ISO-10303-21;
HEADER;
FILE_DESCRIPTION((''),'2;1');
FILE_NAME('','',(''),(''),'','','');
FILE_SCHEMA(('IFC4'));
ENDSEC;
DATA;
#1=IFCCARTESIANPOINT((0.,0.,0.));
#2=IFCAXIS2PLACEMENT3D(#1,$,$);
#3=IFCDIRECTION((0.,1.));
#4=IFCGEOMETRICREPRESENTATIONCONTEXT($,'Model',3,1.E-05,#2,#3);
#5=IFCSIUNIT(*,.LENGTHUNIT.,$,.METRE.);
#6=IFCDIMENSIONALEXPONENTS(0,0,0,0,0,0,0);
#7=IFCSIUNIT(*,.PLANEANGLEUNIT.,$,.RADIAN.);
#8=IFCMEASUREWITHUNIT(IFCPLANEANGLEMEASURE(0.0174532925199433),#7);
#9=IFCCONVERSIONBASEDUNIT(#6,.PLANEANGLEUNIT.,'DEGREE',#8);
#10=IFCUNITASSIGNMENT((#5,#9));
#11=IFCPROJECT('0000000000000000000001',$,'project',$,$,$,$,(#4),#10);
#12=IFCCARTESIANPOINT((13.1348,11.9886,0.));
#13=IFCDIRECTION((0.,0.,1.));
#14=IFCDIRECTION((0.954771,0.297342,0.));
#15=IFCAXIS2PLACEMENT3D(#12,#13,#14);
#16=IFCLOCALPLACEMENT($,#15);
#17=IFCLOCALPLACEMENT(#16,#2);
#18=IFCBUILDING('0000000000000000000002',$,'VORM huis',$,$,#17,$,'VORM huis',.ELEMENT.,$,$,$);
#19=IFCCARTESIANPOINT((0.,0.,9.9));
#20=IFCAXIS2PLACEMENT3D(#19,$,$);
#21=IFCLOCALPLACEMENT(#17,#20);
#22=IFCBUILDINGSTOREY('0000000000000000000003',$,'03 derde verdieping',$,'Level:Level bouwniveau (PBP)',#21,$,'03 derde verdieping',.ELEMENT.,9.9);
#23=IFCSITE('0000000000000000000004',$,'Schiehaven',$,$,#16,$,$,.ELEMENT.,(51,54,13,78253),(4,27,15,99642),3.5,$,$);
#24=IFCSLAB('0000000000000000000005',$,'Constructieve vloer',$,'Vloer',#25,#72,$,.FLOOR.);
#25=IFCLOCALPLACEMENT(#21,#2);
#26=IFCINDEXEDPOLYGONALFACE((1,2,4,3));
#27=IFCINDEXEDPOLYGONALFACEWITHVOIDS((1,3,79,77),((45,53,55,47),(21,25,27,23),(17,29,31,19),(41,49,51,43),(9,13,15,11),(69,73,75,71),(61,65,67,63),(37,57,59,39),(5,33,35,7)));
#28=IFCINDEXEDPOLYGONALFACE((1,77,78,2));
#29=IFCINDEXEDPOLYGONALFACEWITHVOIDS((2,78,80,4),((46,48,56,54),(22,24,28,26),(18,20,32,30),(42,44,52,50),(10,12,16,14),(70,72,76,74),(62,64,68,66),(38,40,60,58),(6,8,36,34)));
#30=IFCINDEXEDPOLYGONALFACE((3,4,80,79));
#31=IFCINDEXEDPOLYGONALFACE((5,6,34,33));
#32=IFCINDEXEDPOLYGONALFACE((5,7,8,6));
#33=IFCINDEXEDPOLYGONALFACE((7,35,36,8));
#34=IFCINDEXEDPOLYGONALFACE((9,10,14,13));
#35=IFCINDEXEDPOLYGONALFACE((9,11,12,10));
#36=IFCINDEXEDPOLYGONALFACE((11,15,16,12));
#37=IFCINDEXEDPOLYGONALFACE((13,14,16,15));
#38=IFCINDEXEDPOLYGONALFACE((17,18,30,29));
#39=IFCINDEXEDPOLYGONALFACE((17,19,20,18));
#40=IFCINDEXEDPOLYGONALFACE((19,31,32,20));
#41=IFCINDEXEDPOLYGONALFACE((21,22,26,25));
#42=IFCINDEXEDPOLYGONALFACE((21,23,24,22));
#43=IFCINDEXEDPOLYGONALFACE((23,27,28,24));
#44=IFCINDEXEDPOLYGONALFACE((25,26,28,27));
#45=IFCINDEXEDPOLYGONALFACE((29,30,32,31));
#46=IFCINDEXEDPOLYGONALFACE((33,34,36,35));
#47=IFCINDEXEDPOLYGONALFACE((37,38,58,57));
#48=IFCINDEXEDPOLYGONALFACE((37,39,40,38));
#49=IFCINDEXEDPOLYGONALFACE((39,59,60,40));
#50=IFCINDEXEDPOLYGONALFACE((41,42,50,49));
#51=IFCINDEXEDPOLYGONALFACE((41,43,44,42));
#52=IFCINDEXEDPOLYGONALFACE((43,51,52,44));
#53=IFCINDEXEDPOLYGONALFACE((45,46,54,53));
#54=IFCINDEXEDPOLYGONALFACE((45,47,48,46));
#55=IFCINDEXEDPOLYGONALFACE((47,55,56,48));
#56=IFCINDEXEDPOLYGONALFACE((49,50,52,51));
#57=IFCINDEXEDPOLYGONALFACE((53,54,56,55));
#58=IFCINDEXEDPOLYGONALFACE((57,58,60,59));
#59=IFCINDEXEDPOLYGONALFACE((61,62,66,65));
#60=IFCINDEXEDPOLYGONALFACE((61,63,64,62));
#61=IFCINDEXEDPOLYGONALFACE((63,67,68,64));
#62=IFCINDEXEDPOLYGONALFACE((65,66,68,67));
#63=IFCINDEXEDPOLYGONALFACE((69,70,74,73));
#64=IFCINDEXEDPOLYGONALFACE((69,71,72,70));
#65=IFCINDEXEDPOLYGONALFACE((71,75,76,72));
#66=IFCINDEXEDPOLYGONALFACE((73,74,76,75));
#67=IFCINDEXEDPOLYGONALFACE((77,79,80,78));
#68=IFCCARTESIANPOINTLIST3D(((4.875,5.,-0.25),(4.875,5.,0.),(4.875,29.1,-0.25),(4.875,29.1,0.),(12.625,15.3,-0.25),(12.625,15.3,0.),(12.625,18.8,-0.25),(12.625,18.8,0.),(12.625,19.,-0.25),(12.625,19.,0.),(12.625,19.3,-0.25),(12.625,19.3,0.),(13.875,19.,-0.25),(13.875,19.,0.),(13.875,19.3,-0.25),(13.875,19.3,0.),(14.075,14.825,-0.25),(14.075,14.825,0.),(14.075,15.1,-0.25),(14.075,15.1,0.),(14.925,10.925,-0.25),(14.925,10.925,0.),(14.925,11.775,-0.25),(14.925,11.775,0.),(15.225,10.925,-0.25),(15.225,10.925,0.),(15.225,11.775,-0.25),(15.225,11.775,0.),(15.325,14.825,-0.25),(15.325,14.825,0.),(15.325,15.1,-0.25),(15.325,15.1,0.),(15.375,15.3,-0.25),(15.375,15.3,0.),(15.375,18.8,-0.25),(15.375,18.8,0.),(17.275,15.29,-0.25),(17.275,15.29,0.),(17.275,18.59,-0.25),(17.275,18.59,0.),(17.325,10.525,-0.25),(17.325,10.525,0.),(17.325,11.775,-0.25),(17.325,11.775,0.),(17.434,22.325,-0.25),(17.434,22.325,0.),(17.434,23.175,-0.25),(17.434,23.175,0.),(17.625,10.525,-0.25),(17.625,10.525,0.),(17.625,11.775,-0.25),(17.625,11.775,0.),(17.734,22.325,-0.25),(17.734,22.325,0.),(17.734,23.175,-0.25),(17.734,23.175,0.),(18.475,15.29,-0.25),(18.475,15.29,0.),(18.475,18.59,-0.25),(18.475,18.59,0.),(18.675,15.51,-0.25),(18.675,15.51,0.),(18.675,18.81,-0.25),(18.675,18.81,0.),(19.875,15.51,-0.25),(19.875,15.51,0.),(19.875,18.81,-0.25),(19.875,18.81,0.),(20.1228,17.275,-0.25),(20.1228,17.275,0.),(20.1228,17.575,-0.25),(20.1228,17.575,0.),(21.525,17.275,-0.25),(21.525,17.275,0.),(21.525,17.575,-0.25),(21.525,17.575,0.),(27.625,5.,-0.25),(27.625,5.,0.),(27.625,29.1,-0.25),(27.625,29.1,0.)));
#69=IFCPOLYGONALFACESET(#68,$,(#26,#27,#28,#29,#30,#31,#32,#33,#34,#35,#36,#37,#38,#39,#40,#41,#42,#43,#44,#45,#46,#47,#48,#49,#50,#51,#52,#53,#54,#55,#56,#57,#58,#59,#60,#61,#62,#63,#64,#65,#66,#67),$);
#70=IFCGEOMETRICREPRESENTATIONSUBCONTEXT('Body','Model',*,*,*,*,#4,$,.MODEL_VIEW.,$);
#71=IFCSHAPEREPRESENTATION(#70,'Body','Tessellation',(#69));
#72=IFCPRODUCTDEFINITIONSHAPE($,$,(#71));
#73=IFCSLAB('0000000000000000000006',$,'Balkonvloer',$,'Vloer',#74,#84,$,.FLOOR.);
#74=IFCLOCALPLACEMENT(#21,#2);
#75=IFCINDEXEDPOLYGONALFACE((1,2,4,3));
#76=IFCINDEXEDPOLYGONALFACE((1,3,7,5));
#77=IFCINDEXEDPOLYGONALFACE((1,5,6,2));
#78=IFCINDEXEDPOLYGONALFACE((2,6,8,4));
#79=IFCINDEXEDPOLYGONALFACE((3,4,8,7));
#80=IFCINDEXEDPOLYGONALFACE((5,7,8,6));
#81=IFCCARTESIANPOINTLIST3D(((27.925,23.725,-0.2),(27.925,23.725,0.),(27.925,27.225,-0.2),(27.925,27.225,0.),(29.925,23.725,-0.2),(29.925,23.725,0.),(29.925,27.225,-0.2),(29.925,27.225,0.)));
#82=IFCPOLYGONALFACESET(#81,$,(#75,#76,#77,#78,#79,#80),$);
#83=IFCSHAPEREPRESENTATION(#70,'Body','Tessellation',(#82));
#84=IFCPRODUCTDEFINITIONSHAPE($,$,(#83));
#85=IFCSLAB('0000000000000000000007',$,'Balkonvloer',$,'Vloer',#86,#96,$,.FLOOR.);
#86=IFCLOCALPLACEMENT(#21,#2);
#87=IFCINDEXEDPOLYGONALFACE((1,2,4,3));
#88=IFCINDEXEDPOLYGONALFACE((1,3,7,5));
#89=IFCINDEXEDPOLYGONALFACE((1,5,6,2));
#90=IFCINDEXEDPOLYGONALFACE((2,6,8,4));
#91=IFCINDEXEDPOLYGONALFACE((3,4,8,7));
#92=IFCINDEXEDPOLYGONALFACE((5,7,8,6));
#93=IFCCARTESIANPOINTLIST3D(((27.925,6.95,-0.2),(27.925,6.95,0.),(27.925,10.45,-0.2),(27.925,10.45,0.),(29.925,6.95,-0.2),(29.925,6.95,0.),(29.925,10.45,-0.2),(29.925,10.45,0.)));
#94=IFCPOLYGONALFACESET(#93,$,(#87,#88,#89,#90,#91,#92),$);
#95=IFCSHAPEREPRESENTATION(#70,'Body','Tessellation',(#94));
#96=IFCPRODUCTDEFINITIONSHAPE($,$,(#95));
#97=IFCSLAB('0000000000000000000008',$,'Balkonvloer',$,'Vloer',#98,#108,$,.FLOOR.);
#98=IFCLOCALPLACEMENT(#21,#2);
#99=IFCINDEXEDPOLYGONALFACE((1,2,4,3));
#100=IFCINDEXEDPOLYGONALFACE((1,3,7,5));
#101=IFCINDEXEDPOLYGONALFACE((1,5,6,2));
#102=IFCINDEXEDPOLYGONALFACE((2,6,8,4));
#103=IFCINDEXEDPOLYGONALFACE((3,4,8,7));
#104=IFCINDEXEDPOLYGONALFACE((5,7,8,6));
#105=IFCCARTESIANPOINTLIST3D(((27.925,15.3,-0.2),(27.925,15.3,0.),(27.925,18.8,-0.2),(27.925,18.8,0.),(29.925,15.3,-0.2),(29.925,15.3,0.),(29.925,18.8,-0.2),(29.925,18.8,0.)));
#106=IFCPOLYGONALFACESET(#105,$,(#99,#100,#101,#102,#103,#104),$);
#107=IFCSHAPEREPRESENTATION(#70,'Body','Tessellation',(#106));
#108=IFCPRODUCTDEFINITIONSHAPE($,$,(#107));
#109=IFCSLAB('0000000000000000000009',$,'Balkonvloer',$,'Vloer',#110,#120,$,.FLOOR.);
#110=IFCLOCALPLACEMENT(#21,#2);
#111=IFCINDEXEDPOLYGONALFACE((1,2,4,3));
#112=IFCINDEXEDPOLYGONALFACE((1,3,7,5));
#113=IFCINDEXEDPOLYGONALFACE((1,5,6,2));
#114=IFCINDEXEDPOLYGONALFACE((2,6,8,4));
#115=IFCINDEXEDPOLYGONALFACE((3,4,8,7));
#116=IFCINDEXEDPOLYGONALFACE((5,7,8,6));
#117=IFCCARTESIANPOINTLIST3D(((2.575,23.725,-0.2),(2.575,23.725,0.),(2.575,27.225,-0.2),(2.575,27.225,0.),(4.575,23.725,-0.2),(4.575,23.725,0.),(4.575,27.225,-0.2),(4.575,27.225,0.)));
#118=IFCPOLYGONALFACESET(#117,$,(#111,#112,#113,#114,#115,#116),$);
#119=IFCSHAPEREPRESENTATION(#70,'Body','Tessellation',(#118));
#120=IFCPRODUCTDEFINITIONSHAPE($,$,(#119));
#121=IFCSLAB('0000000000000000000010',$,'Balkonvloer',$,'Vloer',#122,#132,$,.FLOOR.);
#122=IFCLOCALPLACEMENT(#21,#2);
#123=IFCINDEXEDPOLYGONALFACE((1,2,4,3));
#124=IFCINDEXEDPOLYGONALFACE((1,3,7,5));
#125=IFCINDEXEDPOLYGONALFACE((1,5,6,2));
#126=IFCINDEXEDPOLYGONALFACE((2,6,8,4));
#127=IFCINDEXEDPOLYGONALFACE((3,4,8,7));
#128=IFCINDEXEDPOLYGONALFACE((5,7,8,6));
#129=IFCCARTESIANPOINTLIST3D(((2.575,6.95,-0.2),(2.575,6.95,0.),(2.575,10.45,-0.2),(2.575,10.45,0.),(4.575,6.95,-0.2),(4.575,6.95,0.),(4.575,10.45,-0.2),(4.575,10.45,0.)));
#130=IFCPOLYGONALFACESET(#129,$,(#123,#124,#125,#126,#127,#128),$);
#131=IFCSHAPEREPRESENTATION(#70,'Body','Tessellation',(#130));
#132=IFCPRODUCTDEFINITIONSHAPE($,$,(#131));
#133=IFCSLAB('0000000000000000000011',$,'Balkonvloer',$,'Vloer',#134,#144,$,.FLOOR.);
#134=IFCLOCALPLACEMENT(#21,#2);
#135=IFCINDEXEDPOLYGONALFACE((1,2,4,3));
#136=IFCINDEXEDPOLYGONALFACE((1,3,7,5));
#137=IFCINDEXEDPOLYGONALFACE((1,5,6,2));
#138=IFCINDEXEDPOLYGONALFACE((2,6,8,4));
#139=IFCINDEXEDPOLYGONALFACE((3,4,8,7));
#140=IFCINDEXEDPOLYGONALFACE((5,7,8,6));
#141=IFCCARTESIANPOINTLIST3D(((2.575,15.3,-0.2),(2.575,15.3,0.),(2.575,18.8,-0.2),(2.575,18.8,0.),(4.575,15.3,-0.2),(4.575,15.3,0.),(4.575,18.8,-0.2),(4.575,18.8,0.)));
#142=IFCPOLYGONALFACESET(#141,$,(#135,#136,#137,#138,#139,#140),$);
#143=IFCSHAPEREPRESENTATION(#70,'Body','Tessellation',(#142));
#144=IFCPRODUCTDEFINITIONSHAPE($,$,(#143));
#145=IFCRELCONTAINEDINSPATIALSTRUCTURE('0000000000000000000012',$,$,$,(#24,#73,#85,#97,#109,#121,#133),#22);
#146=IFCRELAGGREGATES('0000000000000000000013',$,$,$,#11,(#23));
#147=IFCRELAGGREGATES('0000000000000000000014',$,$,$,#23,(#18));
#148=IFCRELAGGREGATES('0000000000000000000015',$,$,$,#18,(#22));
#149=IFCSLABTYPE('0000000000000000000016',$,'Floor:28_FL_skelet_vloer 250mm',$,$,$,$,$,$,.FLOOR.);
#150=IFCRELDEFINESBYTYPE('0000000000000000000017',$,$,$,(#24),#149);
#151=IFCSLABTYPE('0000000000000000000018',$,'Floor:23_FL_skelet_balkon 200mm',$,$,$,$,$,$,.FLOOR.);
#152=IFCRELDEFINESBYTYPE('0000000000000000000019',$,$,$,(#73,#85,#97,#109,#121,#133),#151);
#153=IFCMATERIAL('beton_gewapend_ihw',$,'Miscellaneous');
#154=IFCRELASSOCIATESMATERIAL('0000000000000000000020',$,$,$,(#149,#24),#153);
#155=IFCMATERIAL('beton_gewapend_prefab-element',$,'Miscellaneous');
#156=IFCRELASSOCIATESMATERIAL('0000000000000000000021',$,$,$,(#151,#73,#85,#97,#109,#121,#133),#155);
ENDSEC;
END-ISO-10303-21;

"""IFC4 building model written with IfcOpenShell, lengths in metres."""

from ifc_helpers import new_model, entity, si_unit, converted_unit, direction, frame, origin, place, context, subcontext, project, spatial, indexed_curve, outline, extrude, material, type_object, element, save


model = new_model("IFC4")

# Units and contexts
model_context = context("Model", 3, precision=1e-05, world=origin(), true_north=direction((0.0, 1.0)))
body_context = subcontext(model_context, "Body", "Model", "MODEL_VIEW")
ifc_project = project(units=[si_unit("LENGTHUNIT", "METRE"), converted_unit("PLANEANGLEUNIT", "DEGREE", entity("IfcPlaneAngleMeasure", 0.0174532925199433), si_unit("PLANEANGLEUNIT", "RADIAN"), dimensions=[0, 0, 0, 0, 0, 0, 0])], contexts=[model_context])

# Site, building, storey
site_placement = place(None, frame((13.1348, 11.9886, 0.0), z_axis=(0.0, 0.0, 1.0), x_axis=(0.954771, 0.297342, 0.0)))
site = spatial("IfcSite", under=ifc_project, at=site_placement, Name="Schiehaven", CompositionType="ELEMENT", RefLatitude=(51, 54, 13, 78253), RefLongitude=(4, 27, 15, 99642), RefElevation=3.5)
building_placement = place(site_placement, origin())
building = spatial("IfcBuilding", under=site, at=building_placement, Name="VORM huis", LongName="VORM huis", CompositionType="ELEMENT")
storey_placement = place(building_placement, frame((0.0, 0.0, 9.9)))
storey = spatial("IfcBuildingStorey", under=building, at=storey_placement, Name="03 derde verdieping", ObjectType="Level:Level bouwniveau (PBP)", LongName="03 derde verdieping", CompositionType="ELEMENT", Elevation=9.9)

# Slab, openings
ifc_material_1 = material(Name="beton_gewapend_ihw", Category="Miscellaneous")
slab_type_1 = type_object("IfcSlabType", Name="Floor:28_FL_skelet_vloer 250mm", PredefinedType="FLOOR", material=ifc_material_1)
slab_1_placement = place(storey_placement, origin())
slab_1 = element("IfcSlab", 1, at=slab_1_placement, inside=storey, type_object=slab_type_1, material=ifc_material_1, Name="Constructieve vloer", ObjectType="Vloer", PredefinedType="FLOOR", context=body_context, shape_type="SweptSolid", body=[
    extrude(outline(indexed_curve([(-12.05, -11.375), (12.05, -11.375), (12.05, 11.375), (-12.05, 11.375), (-12.05, -11.375)], self_intersect=False), holes=[indexed_curve([(-1.75, -3.625), (-1.75, -0.875), (1.75, -0.875), (1.75, -3.625), (-1.75, -3.625)], self_intersect=False), indexed_curve([(1.76, 2.225), (1.76, 1.025), (-1.54, 1.025), (-1.54, 2.225), (1.76, 2.225)], self_intersect=False), indexed_curve([(-1.76, 3.625), (1.54, 3.625), (1.54, 2.425), (-1.76, 2.425), (-1.76, 3.625)], self_intersect=False), indexed_curve([(5.275, -1.025), (6.125, -1.025), (6.125, -1.325), (5.275, -1.325), (5.275, -1.025)], self_intersect=False), indexed_curve([(5.275, 1.375), (6.525, 1.375), (6.525, 1.075), (5.275, 1.075), (5.275, 1.375)], self_intersect=False), indexed_curve([(-0.525, 5.275), (-0.225, 5.275), (-0.225, 3.8728), (-0.525, 3.8728), (-0.525, 5.275)], self_intersect=False), indexed_curve([(-6.125, 1.484), (-5.275, 1.484), (-5.275, 1.184), (-6.125, 1.184), (-6.125, 1.484)], self_intersect=False), indexed_curve([(1.95, -0.925), (2.225, -0.925), (2.225, -2.175), (1.95, -2.175), (1.95, -0.925)], self_intersect=False), indexed_curve([(-2.25, -2.375), (-1.95, -2.375), (-1.95, -3.625), (-2.25, -3.625), (-2.25, -2.375)], self_intersect=False)]), frame((16.25, 17.05, -0.25), z_axis=(0.0, 0.0, 1.0), x_axis=(0.0, -1.0, 0.0)), (0.0, 0.0, 1.0), 0.25),
])
opening_1_placement = place(slab_1_placement, origin())
element("IfcOpeningElement", 2, at=opening_1_placement, cuts=slab_1, PredefinedType="OPENING", context=body_context, shape_type="SweptSolid", body=[
    extrude(outline(indexed_curve([(-1.75, -1.375), (1.75, -1.375), (1.75, 1.375), (-1.75, 1.375), (-1.75, -1.375)], self_intersect=False)), frame((14.0, 17.05, -0.25), z_axis=(0.0, 0.0, 1.0), x_axis=(0.0, -1.0, 0.0)), (0.0, 0.0, 1.0), 0.25),
])
opening_2_placement = place(slab_1_placement, origin())
element("IfcOpeningElement", 3, at=opening_2_placement, cuts=slab_1, PredefinedType="OPENING", context=body_context, shape_type="SweptSolid", body=[
    extrude(outline(indexed_curve([(-1.65, -0.6), (1.65, -0.6), (1.65, 0.6), (-1.65, 0.6), (-1.65, -0.6)], self_intersect=False)), frame((17.875, 16.94, -0.25), z_axis=(0.0, 0.0, 1.0), x_axis=(0.0, 1.0, 0.0)), (0.0, 0.0, 1.0), 0.25),
])
opening_3_placement = place(slab_1_placement, origin())
element("IfcOpeningElement", 4, at=opening_3_placement, cuts=slab_1, PredefinedType="OPENING", context=body_context, shape_type="SweptSolid", body=[
    extrude(outline(indexed_curve([(-0.15, -0.425), (0.15, -0.425), (0.15, 0.425), (-0.15, 0.425), (-0.15, -0.425)], self_intersect=False)), frame((15.075, 11.35, -0.25), z_axis=(0.0, 0.0, 1.0), x_axis=(-1.0, 0.0, 0.0)), (0.0, 0.0, 1.0), 0.25),
])
opening_4_placement = place(slab_1_placement, origin())
element("IfcOpeningElement", 5, at=opening_4_placement, cuts=slab_1, PredefinedType="OPENING", context=body_context, shape_type="SweptSolid", body=[
    extrude(outline(indexed_curve([(-0.15, -0.625), (0.15, -0.625), (0.15, 0.625), (-0.15, 0.625), (-0.15, -0.625)], self_intersect=False)), frame((17.475, 11.15, -0.25), z_axis=(0.0, 0.0, 1.0), x_axis=(-1.0, 0.0, 0.0)), (0.0, 0.0, 1.0), 0.25),
])
opening_5_placement = place(slab_1_placement, origin())
element("IfcOpeningElement", 6, at=opening_5_placement, cuts=slab_1, PredefinedType="OPENING", context=body_context, shape_type="SweptSolid", body=[
    extrude(outline(indexed_curve([(-0.7011, -0.15), (0.7011, -0.15), (0.7011, 0.15), (-0.7011, 0.15), (-0.7011, -0.15)], self_intersect=False)), frame((20.8239, 17.425, -0.25), z_axis=(0.0, 0.0, 1.0), x_axis=(-1.0, 0.0, 0.0)), (0.0, 0.0, 1.0), 0.25),
])
opening_6_placement = place(slab_1_placement, origin())
element("IfcOpeningElement", 7, at=opening_6_placement, cuts=slab_1, PredefinedType="OPENING", context=body_context, shape_type="SweptSolid", body=[
    extrude(outline(indexed_curve([(-0.15, -0.425), (0.15, -0.425), (0.15, 0.425), (-0.15, 0.425), (-0.15, -0.425)], self_intersect=False)), frame((17.584, 22.75, -0.25), z_axis=(0.0, 0.0, 1.0), x_axis=(-1.0, 0.0, 0.0)), (0.0, 0.0, 1.0), 0.25),
])
opening_7_placement = place(slab_1_placement, origin())
element("IfcOpeningElement", 8, at=opening_7_placement, cuts=slab_1, PredefinedType="OPENING", context=body_context, shape_type="SweptSolid", body=[
    extrude(outline(indexed_curve([(-0.625, -0.1375), (0.625, -0.1375), (0.625, 0.1375), (-0.625, 0.1375), (-0.625, -0.1375)], self_intersect=False)), frame((14.7, 14.9625, -0.25), z_axis=(0.0, 0.0, 1.0), x_axis=(-1.0, 0.0, 0.0)), (0.0, 0.0, 1.0), 0.25),
])
opening_8_placement = place(slab_1_placement, origin())
element("IfcOpeningElement", 9, at=opening_8_placement, cuts=slab_1, PredefinedType="OPENING", context=body_context, shape_type="SweptSolid", body=[
    extrude(outline(indexed_curve([(-0.625, -0.15), (0.625, -0.15), (0.625, 0.15), (-0.625, 0.15), (-0.625, -0.15)], self_intersect=False)), frame((13.25, 19.15, -0.25), z_axis=(0.0, 0.0, 1.0), x_axis=(-1.0, 0.0, 0.0)), (0.0, 0.0, 1.0), 0.25),
])

# Slabs
ifc_material_2 = material(Name="beton_gewapend_prefab-element", Category="Miscellaneous")
slab_type_2 = type_object("IfcSlabType", Name="Floor:23_FL_skelet_balkon 200mm", PredefinedType="FLOOR", material=ifc_material_2)
slab_2_placement = place(storey_placement, origin())
element("IfcSlab", 10, at=slab_2_placement, inside=storey, type_object=slab_type_2, material=ifc_material_2, Name="Balkonvloer", ObjectType="Vloer", PredefinedType="FLOOR", context=body_context, shape_type="SweptSolid", body=[
    extrude(outline(indexed_curve([(-1.75, -1.0), (1.75, -1.0), (1.75, 1.0), (-1.75, 1.0), (-1.75, -1.0)], self_intersect=False)), frame((28.925, 25.475, 0.0), z_axis=(0.0, 0.0, -1.0), x_axis=(0.0, 1.0, 0.0)), (0.0, 0.0, 1.0), 0.2),
])
slab_3_placement = place(storey_placement, origin())
element("IfcSlab", 11, at=slab_3_placement, inside=storey, type_object=slab_type_2, material=ifc_material_2, Name="Balkonvloer", ObjectType="Vloer", PredefinedType="FLOOR", context=body_context, shape_type="SweptSolid", body=[
    extrude(outline(indexed_curve([(-1.75, -1.0), (1.75, -1.0), (1.75, 1.0), (-1.75, 1.0), (-1.75, -1.0)], self_intersect=False)), frame((28.925, 8.7, 0.0), z_axis=(0.0, 0.0, -1.0), x_axis=(0.0, 1.0, 0.0)), (0.0, 0.0, 1.0), 0.2),
])
slab_4_placement = place(storey_placement, origin())
element("IfcSlab", 12, at=slab_4_placement, inside=storey, type_object=slab_type_2, material=ifc_material_2, Name="Balkonvloer", ObjectType="Vloer", PredefinedType="FLOOR", context=body_context, shape_type="SweptSolid", body=[
    extrude(outline(indexed_curve([(-1.75, -1.0), (1.75, -1.0), (1.75, 1.0), (-1.75, 1.0), (-1.75, -1.0)], self_intersect=False)), frame((28.925, 17.05, 0.0), z_axis=(0.0, 0.0, -1.0), x_axis=(0.0, 1.0, 0.0)), (0.0, 0.0, 1.0), 0.2),
])
slab_5_placement = place(storey_placement, origin())
element("IfcSlab", 13, at=slab_5_placement, inside=storey, type_object=slab_type_2, material=ifc_material_2, Name="Balkonvloer", ObjectType="Vloer", PredefinedType="FLOOR", context=body_context, shape_type="SweptSolid", body=[
    extrude(outline(indexed_curve([(-1.75, -1.0), (1.75, -1.0), (1.75, 1.0), (-1.75, 1.0), (-1.75, -1.0)], self_intersect=False)), frame((3.575, 25.475, 0.0), z_axis=(0.0, 0.0, -1.0), x_axis=(0.0, 1.0, 0.0)), (0.0, 0.0, 1.0), 0.2),
])
slab_6_placement = place(storey_placement, origin())
element("IfcSlab", 14, at=slab_6_placement, inside=storey, type_object=slab_type_2, material=ifc_material_2, Name="Balkonvloer", ObjectType="Vloer", PredefinedType="FLOOR", context=body_context, shape_type="SweptSolid", body=[
    extrude(outline(indexed_curve([(-1.75, -1.0), (1.75, -1.0), (1.75, 1.0), (-1.75, 1.0), (-1.75, -1.0)], self_intersect=False)), frame((3.575, 8.7, 0.0), z_axis=(0.0, 0.0, -1.0), x_axis=(0.0, 1.0, 0.0)), (0.0, 0.0, 1.0), 0.2),
])
slab_7_placement = place(storey_placement, origin())
element("IfcSlab", 15, at=slab_7_placement, inside=storey, type_object=slab_type_2, material=ifc_material_2, Name="Balkonvloer", ObjectType="Vloer", PredefinedType="FLOOR", context=body_context, shape_type="SweptSolid", body=[
    extrude(outline(indexed_curve([(-1.75, -1.0), (1.75, -1.0), (1.75, 1.0), (-1.75, 1.0), (-1.75, -1.0)], self_intersect=False)), frame((3.575, 17.05, 0.0), z_axis=(0.0, 0.0, -1.0), x_axis=(0.0, 1.0, 0.0)), (0.0, 0.0, 1.0), 0.2),
])

save(model, "model.ifc")
